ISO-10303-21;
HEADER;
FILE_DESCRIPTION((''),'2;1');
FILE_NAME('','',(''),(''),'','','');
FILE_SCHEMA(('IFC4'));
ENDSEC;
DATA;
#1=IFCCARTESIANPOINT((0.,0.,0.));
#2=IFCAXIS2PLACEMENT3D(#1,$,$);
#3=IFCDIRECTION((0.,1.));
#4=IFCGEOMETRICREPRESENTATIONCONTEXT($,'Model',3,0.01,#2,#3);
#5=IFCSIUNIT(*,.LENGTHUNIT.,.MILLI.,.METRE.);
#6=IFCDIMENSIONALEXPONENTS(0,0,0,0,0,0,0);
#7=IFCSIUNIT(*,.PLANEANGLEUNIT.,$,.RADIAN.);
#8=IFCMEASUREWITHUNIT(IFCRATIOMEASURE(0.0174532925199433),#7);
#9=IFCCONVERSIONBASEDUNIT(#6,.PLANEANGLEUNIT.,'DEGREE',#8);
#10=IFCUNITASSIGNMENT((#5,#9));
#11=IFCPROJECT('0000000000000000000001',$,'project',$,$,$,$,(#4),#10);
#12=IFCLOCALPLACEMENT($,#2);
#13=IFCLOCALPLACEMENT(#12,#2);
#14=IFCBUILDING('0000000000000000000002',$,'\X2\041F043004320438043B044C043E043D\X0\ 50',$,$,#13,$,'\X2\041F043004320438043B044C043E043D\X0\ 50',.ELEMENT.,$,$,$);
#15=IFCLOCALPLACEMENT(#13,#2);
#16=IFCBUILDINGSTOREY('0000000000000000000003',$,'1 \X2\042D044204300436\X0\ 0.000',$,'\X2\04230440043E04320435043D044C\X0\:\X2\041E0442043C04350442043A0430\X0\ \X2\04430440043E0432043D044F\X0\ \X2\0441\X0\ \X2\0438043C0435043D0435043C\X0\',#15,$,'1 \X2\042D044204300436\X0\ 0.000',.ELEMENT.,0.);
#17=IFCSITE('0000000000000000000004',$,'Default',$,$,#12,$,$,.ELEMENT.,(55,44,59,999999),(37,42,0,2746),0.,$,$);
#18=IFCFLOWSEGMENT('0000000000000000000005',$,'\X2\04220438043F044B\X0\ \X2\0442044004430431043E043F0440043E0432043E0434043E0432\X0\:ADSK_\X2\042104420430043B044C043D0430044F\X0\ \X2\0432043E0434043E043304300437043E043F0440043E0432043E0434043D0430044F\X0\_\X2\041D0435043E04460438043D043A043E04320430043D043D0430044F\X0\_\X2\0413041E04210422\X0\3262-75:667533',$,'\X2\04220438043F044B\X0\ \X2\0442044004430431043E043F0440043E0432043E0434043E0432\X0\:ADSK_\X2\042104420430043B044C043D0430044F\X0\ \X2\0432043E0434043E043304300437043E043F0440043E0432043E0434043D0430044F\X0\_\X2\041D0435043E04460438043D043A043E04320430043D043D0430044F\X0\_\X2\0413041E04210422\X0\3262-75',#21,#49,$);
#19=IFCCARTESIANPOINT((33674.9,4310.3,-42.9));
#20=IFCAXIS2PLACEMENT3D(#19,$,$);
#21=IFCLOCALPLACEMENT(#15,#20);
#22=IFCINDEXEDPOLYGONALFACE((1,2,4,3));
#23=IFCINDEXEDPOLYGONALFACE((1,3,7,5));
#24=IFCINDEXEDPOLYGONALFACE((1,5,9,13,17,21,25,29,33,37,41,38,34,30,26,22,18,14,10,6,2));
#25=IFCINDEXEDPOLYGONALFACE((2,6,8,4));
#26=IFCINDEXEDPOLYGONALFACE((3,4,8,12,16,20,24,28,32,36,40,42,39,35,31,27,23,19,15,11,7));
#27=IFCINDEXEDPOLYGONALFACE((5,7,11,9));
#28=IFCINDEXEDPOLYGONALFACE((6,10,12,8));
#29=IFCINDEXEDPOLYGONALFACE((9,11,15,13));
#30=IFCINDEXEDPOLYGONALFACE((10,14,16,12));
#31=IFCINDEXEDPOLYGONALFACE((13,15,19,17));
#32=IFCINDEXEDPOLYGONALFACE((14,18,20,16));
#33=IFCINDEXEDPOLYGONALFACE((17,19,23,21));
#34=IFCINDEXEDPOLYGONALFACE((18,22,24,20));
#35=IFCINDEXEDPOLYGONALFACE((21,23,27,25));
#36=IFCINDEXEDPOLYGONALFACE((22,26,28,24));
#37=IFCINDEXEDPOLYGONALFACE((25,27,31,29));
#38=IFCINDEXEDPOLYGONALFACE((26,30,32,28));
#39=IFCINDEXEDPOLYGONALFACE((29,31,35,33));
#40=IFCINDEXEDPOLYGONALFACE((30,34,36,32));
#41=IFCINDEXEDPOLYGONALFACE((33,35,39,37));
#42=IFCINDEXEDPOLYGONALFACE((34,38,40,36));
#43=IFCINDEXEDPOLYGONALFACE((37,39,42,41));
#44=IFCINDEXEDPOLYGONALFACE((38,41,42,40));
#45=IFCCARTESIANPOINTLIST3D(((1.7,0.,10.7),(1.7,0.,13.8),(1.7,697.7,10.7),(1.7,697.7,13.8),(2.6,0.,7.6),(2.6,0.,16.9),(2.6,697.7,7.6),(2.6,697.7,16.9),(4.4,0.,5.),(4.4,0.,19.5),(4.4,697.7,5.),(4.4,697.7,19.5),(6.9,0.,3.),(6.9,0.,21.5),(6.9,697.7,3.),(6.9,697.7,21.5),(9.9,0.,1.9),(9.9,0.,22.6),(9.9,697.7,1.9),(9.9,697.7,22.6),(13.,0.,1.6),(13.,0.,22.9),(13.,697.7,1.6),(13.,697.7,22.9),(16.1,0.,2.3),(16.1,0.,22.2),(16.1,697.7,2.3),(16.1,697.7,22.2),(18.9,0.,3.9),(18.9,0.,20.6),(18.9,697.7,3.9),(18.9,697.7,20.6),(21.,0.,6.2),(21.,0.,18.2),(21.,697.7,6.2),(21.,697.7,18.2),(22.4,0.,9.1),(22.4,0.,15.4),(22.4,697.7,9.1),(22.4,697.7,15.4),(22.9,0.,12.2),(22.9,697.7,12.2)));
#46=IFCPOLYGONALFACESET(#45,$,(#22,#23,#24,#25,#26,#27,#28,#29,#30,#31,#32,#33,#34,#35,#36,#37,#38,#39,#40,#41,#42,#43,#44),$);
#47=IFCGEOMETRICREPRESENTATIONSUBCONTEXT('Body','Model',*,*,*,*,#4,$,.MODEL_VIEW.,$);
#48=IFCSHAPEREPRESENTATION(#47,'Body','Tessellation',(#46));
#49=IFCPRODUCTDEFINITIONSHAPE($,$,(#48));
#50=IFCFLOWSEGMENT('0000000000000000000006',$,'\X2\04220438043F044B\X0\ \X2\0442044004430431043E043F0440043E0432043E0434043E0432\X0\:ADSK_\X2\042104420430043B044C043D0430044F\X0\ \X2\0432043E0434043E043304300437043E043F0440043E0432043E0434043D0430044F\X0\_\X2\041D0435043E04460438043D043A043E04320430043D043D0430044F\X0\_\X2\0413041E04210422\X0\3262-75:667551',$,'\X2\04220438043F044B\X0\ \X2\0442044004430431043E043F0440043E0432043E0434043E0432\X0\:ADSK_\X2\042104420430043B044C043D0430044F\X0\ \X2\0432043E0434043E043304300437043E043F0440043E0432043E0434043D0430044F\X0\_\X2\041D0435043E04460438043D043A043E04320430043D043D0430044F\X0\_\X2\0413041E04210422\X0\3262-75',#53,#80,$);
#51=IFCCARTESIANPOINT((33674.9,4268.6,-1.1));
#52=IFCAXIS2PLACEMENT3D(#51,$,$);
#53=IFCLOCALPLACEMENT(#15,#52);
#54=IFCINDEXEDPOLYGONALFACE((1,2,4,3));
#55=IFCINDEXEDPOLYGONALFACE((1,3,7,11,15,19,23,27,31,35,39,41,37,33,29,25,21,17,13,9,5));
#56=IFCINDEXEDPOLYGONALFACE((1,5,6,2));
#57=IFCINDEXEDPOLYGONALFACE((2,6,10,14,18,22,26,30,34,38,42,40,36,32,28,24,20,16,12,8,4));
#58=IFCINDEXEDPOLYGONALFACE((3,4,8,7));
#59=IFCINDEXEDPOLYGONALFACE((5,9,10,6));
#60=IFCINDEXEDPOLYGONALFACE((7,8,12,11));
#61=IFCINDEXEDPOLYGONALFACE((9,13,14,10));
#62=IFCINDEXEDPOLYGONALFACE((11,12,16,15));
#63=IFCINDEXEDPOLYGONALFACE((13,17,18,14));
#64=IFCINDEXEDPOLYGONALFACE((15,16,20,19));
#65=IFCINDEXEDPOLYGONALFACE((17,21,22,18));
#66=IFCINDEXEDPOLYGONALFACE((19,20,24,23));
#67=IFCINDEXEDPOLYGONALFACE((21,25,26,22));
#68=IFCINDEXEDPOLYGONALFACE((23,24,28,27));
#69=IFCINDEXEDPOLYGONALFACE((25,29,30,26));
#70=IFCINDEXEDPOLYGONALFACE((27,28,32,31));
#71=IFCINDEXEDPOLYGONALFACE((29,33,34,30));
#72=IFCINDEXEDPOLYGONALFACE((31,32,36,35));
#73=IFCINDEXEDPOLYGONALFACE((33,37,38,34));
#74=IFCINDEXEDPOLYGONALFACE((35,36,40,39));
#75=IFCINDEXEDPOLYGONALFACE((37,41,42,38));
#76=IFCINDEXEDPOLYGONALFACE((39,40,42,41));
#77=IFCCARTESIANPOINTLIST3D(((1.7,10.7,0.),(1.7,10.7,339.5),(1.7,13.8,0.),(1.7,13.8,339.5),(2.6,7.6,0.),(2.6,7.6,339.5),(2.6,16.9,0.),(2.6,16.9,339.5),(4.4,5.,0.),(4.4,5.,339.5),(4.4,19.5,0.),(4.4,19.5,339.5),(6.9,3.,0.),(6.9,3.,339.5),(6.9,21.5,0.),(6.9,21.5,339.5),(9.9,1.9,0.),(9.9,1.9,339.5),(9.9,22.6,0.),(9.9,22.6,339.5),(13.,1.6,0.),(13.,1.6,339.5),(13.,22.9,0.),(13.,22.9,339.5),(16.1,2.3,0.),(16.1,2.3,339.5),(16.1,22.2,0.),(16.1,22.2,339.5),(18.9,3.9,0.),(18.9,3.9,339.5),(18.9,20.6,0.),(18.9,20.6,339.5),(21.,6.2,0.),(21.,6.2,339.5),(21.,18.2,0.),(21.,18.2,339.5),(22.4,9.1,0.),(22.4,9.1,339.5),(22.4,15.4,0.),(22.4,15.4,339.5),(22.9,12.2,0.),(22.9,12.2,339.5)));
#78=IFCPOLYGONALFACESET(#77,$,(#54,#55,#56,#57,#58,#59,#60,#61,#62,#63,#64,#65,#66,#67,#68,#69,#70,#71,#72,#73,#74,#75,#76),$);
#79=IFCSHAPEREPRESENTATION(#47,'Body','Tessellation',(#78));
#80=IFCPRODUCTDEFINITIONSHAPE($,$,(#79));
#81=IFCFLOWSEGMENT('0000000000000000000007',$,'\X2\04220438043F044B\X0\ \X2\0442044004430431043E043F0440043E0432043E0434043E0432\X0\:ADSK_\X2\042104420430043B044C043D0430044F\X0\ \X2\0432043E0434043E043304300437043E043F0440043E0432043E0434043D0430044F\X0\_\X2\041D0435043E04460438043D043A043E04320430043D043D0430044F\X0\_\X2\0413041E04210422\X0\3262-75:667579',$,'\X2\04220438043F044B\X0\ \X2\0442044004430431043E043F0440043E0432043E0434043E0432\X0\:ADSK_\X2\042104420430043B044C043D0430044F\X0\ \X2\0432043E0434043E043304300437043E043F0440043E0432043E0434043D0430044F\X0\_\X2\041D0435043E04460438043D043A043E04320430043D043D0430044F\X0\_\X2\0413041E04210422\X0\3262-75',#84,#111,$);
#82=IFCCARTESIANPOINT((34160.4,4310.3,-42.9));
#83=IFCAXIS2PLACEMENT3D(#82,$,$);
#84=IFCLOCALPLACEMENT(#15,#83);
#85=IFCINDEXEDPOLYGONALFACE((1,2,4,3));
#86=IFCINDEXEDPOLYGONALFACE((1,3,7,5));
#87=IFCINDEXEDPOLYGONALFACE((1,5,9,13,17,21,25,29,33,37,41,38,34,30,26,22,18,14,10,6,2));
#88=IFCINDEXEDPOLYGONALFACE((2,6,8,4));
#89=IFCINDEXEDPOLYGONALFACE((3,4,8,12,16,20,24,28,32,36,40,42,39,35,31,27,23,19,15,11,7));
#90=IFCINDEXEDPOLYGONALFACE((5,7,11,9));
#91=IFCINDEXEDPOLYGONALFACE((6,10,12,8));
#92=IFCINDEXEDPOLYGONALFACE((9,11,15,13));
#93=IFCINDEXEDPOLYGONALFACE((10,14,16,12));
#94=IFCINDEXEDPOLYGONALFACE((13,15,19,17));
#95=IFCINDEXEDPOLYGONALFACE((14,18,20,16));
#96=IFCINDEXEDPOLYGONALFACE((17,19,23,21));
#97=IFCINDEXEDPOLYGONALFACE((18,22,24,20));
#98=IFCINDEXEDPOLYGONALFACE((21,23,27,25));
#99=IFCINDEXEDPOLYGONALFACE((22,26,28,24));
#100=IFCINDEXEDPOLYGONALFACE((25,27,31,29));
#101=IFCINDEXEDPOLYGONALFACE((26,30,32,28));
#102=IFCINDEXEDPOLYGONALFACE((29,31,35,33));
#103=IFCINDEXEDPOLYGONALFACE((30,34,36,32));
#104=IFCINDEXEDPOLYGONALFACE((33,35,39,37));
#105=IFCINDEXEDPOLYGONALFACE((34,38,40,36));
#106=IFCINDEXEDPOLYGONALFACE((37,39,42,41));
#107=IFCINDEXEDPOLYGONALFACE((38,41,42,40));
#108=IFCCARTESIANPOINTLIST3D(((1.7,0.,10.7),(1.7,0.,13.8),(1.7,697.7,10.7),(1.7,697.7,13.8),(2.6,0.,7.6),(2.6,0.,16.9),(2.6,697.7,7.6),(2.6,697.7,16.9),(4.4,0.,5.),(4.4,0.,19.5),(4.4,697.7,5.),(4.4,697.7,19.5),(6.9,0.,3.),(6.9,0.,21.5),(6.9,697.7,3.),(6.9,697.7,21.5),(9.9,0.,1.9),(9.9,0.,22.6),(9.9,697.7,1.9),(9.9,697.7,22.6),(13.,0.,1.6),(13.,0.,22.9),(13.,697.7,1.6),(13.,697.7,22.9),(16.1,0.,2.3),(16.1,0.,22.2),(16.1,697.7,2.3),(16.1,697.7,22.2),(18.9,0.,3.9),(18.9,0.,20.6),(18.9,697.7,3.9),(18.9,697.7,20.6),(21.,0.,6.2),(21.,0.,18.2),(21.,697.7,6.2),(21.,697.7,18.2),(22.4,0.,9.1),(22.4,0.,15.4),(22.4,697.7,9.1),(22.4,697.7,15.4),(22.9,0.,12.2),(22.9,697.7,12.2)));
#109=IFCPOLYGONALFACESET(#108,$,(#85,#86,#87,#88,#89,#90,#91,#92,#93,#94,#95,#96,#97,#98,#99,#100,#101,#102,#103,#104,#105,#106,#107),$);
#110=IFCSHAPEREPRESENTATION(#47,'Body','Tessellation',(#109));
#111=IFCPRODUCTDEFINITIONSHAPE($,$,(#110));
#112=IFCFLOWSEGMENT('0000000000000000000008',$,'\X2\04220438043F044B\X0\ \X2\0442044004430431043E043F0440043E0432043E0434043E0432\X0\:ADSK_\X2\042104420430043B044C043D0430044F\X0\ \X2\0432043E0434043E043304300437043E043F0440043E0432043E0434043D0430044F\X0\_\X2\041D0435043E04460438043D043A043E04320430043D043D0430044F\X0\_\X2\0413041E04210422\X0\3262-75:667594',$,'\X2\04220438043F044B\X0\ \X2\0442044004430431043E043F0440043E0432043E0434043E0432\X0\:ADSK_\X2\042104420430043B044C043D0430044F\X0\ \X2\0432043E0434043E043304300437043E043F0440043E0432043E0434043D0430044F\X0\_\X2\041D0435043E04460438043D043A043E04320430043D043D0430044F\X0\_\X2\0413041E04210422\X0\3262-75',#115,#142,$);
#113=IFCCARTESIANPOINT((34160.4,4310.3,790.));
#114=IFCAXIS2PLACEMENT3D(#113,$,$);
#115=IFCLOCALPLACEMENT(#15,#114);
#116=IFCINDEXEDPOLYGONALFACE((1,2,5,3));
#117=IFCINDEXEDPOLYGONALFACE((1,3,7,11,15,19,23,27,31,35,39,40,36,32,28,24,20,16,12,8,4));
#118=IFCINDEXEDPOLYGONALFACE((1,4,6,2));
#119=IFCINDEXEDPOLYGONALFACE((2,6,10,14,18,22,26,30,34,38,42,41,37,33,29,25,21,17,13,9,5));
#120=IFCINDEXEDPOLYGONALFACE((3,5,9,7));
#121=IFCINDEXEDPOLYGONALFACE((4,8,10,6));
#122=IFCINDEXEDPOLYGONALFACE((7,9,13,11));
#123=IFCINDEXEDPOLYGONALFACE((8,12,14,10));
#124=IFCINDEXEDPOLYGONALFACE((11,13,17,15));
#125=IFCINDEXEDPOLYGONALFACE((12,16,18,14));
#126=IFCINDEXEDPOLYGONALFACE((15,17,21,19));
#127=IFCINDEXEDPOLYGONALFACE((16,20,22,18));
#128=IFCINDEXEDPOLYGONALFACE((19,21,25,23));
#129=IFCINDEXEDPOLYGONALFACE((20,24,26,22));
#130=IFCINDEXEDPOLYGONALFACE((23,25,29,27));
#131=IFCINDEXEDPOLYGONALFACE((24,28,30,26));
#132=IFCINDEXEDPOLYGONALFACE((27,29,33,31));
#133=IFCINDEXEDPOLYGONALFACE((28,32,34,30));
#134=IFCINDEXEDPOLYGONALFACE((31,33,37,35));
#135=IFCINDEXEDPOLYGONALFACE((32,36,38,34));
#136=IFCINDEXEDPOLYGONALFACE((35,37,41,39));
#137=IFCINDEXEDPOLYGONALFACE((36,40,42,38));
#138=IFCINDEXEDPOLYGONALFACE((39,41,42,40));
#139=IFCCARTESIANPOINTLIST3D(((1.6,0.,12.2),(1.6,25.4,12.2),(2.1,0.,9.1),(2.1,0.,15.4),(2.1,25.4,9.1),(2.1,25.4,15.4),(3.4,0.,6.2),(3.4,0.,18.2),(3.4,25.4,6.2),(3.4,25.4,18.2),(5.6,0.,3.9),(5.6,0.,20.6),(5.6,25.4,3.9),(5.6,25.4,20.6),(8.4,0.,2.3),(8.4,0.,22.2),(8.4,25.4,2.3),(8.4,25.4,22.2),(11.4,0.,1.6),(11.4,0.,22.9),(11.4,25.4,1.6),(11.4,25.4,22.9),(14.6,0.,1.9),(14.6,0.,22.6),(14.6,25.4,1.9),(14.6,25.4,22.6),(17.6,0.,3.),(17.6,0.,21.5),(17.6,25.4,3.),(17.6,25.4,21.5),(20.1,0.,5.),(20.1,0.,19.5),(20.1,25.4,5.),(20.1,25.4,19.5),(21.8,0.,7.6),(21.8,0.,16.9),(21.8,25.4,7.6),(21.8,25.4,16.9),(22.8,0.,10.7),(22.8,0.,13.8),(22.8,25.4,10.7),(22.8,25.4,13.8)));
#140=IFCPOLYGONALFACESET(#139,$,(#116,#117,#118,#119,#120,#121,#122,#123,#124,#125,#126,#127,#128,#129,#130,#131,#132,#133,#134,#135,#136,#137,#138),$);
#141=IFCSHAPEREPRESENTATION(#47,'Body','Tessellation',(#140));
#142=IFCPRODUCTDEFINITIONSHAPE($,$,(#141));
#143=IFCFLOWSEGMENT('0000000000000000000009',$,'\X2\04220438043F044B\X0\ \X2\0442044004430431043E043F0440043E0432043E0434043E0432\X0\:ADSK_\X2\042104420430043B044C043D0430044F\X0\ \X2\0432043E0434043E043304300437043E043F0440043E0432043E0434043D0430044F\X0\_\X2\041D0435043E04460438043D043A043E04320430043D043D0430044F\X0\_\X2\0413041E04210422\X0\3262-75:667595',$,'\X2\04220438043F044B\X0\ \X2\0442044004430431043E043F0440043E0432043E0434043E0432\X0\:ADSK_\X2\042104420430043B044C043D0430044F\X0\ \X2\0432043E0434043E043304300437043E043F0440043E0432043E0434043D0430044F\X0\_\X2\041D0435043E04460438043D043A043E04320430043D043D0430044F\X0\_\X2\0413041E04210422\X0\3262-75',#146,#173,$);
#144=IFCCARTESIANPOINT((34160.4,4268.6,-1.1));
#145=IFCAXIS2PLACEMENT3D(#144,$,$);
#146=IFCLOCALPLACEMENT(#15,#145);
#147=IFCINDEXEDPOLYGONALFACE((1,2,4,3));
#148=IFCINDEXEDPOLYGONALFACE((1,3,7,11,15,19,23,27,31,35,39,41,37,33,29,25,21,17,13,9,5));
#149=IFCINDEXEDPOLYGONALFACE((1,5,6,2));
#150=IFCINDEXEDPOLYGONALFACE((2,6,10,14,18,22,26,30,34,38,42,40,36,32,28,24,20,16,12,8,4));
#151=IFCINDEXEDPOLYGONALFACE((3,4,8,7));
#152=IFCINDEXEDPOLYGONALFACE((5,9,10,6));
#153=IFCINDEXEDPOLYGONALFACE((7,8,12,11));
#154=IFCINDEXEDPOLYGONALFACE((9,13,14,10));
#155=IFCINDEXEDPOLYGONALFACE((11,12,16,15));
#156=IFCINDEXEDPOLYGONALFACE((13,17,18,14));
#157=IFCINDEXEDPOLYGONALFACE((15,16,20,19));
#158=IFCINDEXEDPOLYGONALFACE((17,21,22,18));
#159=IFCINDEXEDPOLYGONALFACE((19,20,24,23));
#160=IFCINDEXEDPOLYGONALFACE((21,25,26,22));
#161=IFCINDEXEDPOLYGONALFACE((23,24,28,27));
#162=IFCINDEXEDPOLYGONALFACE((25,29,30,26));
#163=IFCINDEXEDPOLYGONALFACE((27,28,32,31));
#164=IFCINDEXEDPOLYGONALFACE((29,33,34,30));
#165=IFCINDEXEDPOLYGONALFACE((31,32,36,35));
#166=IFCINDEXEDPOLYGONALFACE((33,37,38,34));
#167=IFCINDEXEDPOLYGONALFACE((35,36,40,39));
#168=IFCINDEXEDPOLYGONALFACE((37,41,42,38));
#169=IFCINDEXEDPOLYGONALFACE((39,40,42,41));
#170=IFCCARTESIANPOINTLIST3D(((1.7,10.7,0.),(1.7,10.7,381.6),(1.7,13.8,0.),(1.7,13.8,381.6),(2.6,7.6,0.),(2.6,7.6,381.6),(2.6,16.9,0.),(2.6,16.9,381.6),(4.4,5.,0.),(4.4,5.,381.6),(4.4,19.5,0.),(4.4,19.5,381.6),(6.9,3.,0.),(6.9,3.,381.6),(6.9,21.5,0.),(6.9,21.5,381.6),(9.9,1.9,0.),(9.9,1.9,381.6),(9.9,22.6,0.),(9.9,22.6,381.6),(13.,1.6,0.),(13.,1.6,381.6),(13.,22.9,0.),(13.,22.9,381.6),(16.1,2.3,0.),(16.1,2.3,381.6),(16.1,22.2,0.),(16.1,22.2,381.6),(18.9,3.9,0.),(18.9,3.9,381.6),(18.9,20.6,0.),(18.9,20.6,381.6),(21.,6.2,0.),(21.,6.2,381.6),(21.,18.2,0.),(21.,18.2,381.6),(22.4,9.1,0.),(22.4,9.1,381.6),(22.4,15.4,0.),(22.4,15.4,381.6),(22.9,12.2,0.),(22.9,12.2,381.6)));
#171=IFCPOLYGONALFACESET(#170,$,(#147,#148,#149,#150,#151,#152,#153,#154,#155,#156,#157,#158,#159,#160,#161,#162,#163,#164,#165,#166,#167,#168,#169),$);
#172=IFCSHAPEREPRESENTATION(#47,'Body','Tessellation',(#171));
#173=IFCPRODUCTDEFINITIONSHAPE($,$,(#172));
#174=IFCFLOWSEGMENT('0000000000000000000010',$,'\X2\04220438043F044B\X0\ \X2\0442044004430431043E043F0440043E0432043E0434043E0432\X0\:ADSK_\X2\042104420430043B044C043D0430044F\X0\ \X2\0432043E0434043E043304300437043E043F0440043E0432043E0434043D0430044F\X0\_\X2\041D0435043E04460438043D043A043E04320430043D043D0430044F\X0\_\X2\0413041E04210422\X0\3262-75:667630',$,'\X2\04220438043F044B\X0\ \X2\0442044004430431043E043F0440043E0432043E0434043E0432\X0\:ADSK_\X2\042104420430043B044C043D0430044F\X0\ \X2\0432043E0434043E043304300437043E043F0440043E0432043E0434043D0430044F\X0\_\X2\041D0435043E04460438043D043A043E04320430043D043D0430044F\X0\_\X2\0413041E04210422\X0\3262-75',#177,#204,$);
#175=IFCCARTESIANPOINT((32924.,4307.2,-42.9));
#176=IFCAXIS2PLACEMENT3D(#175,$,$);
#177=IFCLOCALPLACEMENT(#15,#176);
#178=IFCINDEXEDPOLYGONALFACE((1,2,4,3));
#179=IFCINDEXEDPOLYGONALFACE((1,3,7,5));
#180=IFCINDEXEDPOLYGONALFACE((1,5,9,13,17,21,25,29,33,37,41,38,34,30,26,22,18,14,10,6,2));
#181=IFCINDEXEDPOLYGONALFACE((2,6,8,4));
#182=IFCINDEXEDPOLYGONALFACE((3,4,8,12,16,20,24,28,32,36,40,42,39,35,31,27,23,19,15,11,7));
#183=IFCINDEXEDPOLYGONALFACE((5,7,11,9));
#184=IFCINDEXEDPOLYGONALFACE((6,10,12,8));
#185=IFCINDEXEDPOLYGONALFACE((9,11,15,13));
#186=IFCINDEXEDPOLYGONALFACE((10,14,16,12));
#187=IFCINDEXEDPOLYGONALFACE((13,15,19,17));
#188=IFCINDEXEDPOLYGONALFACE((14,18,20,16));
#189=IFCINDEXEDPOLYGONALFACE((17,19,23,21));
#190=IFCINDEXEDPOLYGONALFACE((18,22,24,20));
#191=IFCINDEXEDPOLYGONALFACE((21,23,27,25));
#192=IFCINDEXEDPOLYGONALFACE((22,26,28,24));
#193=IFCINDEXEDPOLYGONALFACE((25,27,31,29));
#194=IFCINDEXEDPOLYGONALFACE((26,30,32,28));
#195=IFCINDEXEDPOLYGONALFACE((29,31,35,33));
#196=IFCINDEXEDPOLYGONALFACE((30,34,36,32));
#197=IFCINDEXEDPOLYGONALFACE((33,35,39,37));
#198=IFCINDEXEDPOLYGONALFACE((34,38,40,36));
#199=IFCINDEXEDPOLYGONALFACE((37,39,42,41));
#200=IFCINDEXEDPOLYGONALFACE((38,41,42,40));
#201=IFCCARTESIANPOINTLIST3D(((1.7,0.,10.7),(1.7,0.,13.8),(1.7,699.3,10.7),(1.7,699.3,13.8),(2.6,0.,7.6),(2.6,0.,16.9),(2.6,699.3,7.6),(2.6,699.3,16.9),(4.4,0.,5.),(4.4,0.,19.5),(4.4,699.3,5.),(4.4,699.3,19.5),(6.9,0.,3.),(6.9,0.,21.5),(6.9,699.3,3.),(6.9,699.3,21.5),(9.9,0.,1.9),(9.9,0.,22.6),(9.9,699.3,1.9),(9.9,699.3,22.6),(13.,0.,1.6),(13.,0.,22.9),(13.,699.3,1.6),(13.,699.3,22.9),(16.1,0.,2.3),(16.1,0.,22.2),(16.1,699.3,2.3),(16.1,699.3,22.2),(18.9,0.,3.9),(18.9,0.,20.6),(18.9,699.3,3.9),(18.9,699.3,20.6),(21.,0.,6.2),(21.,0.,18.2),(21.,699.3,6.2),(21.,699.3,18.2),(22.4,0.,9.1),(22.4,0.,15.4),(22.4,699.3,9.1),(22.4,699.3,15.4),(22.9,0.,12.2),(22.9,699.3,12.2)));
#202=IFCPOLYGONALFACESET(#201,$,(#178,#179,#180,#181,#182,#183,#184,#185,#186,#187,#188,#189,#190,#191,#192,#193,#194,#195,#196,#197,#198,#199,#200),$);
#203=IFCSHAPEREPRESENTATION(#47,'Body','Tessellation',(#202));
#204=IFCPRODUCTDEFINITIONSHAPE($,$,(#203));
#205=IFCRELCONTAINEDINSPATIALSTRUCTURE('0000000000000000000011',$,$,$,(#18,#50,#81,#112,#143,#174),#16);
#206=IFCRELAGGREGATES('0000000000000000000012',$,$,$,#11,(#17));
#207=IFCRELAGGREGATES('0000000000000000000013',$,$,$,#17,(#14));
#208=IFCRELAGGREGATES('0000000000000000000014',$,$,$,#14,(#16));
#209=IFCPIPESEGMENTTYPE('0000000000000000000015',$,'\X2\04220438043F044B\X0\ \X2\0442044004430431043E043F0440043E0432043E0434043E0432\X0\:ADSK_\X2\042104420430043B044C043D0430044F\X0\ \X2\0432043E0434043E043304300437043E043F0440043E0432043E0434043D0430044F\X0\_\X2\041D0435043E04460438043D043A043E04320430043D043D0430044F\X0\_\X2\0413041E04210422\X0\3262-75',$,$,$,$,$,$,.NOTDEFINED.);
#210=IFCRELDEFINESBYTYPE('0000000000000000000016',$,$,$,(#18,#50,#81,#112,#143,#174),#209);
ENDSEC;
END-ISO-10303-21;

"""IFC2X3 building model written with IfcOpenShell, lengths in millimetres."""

from ifc_helpers import new_model, entity, si_unit, converted_unit, direction, frame, frame_2d, origin, origin_2d_with_axis, place, context, subcontext, project, spatial, circle, extrude, type_object, element, save


model = new_model("IFC2X3")

# Units and contexts
model_context = context("Model", 3, precision=0.01, world=origin(), true_north=direction((0.0, 1.0)))
body_context = subcontext(model_context, "Body", "Model", "MODEL_VIEW")
ifc_project = project(units=[si_unit("LENGTHUNIT", "METRE", prefix="MILLI"), converted_unit("PLANEANGLEUNIT", "DEGREE", entity("IfcRatioMeasure", 0.0174532925199433), si_unit("PLANEANGLEUNIT", "RADIAN"), dimensions=[0, 0, 0, 0, 0, 0, 0])], contexts=[model_context])

# Site, building, storey
site_placement = place(None, origin())
site = spatial("IfcSite", under=ifc_project, at=site_placement, Name="Default", CompositionType="ELEMENT", RefLatitude=(55, 44, 59, 999999), RefLongitude=(37, 42, 0, 2746), RefElevation=0.0)
building_placement = place(site_placement, origin())
building = spatial("IfcBuilding", under=site, at=building_placement, Name="Павильон 50", LongName="Павильон 50", CompositionType="ELEMENT")
storey_placement = place(building_placement, origin())
storey = spatial("IfcBuildingStorey", under=building, at=storey_placement, Name="1 Этаж 0.000", ObjectType="Уровень:Отметка уровня с именем", LongName="1 Этаж 0.000", CompositionType="ELEMENT", Elevation=0.0)

# Flow segments
pipe_segment_type = type_object("IfcPipeSegmentType", Name="Типы трубопроводов:ADSK_Стальная водогазопроводная_Неоцинкованная_ГОСТ3262-75", PredefinedType="NOTDEFINED")
flow_segment_1_placement = place(storey_placement, frame((33674.9, 4310.3, -42.9)))
element("IfcFlowSegment", 1, at=flow_segment_1_placement, inside=storey, type_object=pipe_segment_type, Name="Типы трубопроводов:ADSK_Стальная водогазопроводная_Неоцинкованная_ГОСТ3262-75:667533", ObjectType="Типы трубопроводов:ADSK_Стальная водогазопроводная_Неоцинкованная_ГОСТ3262-75", context=body_context, shape_type="SweptSolid", body=[
    extrude(circle(Radius=10.7, at=frame_2d((0.0, 0.0), x_axis=(1.0, 0.0))), frame((12.2, 0.0, 12.2), z_axis=(0.0, 1.0, 0.0), x_axis=(1.0, 0.0, 0.0)), (0.0, 0.0, 1.0), 697.7),
])
flow_segment_2_placement = place(storey_placement, frame((33674.9, 4268.6, -1.1)))
element("IfcFlowSegment", 2, at=flow_segment_2_placement, inside=storey, type_object=pipe_segment_type, Name="Типы трубопроводов:ADSK_Стальная водогазопроводная_Неоцинкованная_ГОСТ3262-75:667551", ObjectType="Типы трубопроводов:ADSK_Стальная водогазопроводная_Неоцинкованная_ГОСТ3262-75", context=body_context, shape_type="SweptSolid", body=[
    extrude(circle(Radius=10.7, at=origin_2d_with_axis()), frame((12.2, 12.2, 0.0)), (0.0, 0.0, 1.0), 339.5),
])
flow_segment_3_placement = place(storey_placement, frame((34160.4, 4310.3, -42.9)))
element("IfcFlowSegment", 3, at=flow_segment_3_placement, inside=storey, type_object=pipe_segment_type, Name="Типы трубопроводов:ADSK_Стальная водогазопроводная_Неоцинкованная_ГОСТ3262-75:667579", ObjectType="Типы трубопроводов:ADSK_Стальная водогазопроводная_Неоцинкованная_ГОСТ3262-75", context=body_context, shape_type="SweptSolid", body=[
    extrude(circle(Radius=10.7, at=frame_2d((0.0, 0.0), x_axis=(1.0, 0.0))), frame((12.2, 0.0, 12.2), z_axis=(0.0, 1.0, 0.0), x_axis=(1.0, 0.0, 0.0)), (0.0, 0.0, 1.0), 697.7),
])
flow_segment_4_placement = place(storey_placement, frame((34160.4, 4310.3, 790.0)))
element("IfcFlowSegment", 4, at=flow_segment_4_placement, inside=storey, type_object=pipe_segment_type, Name="Типы трубопроводов:ADSK_Стальная водогазопроводная_Неоцинкованная_ГОСТ3262-75:667594", ObjectType="Типы трубопроводов:ADSK_Стальная водогазопроводная_Неоцинкованная_ГОСТ3262-75", context=body_context, shape_type="SweptSolid", body=[
    extrude(circle(Radius=10.7, at=origin_2d_with_axis()), frame((12.2, 0.0, 12.2), z_axis=(0.0, 1.0, 0.0), x_axis=(-1.0, 0.0, 0.0)), (0.0, 0.0, 1.0), 25.4),
])
flow_segment_5_placement = place(storey_placement, frame((34160.4, 4268.6, -1.1)))
element("IfcFlowSegment", 5, at=flow_segment_5_placement, inside=storey, type_object=pipe_segment_type, Name="Типы трубопроводов:ADSK_Стальная водогазопроводная_Неоцинкованная_ГОСТ3262-75:667595", ObjectType="Типы трубопроводов:ADSK_Стальная водогазопроводная_Неоцинкованная_ГОСТ3262-75", context=body_context, shape_type="SweptSolid", body=[
    extrude(circle(Radius=10.7, at=origin_2d_with_axis()), frame((12.2, 12.2, 0.0)), (0.0, 0.0, 1.0), 381.6),
])
flow_segment_6_placement = place(storey_placement, frame((32924.0, 4307.2, -42.9)))
element("IfcFlowSegment", 6, at=flow_segment_6_placement, inside=storey, type_object=pipe_segment_type, Name="Типы трубопроводов:ADSK_Стальная водогазопроводная_Неоцинкованная_ГОСТ3262-75:667630", ObjectType="Типы трубопроводов:ADSK_Стальная водогазопроводная_Неоцинкованная_ГОСТ3262-75", context=body_context, shape_type="SweptSolid", body=[
    extrude(circle(Radius=10.7, at=frame_2d((0.0, 0.0), x_axis=(1.0, 0.0))), frame((12.2, 0.0, 12.2), z_axis=(0.0, 1.0, 0.0), x_axis=(1.0, 0.0, 0.0)), (0.0, 0.0, 1.0), 699.3),
])

save(model, "model.ifc")
